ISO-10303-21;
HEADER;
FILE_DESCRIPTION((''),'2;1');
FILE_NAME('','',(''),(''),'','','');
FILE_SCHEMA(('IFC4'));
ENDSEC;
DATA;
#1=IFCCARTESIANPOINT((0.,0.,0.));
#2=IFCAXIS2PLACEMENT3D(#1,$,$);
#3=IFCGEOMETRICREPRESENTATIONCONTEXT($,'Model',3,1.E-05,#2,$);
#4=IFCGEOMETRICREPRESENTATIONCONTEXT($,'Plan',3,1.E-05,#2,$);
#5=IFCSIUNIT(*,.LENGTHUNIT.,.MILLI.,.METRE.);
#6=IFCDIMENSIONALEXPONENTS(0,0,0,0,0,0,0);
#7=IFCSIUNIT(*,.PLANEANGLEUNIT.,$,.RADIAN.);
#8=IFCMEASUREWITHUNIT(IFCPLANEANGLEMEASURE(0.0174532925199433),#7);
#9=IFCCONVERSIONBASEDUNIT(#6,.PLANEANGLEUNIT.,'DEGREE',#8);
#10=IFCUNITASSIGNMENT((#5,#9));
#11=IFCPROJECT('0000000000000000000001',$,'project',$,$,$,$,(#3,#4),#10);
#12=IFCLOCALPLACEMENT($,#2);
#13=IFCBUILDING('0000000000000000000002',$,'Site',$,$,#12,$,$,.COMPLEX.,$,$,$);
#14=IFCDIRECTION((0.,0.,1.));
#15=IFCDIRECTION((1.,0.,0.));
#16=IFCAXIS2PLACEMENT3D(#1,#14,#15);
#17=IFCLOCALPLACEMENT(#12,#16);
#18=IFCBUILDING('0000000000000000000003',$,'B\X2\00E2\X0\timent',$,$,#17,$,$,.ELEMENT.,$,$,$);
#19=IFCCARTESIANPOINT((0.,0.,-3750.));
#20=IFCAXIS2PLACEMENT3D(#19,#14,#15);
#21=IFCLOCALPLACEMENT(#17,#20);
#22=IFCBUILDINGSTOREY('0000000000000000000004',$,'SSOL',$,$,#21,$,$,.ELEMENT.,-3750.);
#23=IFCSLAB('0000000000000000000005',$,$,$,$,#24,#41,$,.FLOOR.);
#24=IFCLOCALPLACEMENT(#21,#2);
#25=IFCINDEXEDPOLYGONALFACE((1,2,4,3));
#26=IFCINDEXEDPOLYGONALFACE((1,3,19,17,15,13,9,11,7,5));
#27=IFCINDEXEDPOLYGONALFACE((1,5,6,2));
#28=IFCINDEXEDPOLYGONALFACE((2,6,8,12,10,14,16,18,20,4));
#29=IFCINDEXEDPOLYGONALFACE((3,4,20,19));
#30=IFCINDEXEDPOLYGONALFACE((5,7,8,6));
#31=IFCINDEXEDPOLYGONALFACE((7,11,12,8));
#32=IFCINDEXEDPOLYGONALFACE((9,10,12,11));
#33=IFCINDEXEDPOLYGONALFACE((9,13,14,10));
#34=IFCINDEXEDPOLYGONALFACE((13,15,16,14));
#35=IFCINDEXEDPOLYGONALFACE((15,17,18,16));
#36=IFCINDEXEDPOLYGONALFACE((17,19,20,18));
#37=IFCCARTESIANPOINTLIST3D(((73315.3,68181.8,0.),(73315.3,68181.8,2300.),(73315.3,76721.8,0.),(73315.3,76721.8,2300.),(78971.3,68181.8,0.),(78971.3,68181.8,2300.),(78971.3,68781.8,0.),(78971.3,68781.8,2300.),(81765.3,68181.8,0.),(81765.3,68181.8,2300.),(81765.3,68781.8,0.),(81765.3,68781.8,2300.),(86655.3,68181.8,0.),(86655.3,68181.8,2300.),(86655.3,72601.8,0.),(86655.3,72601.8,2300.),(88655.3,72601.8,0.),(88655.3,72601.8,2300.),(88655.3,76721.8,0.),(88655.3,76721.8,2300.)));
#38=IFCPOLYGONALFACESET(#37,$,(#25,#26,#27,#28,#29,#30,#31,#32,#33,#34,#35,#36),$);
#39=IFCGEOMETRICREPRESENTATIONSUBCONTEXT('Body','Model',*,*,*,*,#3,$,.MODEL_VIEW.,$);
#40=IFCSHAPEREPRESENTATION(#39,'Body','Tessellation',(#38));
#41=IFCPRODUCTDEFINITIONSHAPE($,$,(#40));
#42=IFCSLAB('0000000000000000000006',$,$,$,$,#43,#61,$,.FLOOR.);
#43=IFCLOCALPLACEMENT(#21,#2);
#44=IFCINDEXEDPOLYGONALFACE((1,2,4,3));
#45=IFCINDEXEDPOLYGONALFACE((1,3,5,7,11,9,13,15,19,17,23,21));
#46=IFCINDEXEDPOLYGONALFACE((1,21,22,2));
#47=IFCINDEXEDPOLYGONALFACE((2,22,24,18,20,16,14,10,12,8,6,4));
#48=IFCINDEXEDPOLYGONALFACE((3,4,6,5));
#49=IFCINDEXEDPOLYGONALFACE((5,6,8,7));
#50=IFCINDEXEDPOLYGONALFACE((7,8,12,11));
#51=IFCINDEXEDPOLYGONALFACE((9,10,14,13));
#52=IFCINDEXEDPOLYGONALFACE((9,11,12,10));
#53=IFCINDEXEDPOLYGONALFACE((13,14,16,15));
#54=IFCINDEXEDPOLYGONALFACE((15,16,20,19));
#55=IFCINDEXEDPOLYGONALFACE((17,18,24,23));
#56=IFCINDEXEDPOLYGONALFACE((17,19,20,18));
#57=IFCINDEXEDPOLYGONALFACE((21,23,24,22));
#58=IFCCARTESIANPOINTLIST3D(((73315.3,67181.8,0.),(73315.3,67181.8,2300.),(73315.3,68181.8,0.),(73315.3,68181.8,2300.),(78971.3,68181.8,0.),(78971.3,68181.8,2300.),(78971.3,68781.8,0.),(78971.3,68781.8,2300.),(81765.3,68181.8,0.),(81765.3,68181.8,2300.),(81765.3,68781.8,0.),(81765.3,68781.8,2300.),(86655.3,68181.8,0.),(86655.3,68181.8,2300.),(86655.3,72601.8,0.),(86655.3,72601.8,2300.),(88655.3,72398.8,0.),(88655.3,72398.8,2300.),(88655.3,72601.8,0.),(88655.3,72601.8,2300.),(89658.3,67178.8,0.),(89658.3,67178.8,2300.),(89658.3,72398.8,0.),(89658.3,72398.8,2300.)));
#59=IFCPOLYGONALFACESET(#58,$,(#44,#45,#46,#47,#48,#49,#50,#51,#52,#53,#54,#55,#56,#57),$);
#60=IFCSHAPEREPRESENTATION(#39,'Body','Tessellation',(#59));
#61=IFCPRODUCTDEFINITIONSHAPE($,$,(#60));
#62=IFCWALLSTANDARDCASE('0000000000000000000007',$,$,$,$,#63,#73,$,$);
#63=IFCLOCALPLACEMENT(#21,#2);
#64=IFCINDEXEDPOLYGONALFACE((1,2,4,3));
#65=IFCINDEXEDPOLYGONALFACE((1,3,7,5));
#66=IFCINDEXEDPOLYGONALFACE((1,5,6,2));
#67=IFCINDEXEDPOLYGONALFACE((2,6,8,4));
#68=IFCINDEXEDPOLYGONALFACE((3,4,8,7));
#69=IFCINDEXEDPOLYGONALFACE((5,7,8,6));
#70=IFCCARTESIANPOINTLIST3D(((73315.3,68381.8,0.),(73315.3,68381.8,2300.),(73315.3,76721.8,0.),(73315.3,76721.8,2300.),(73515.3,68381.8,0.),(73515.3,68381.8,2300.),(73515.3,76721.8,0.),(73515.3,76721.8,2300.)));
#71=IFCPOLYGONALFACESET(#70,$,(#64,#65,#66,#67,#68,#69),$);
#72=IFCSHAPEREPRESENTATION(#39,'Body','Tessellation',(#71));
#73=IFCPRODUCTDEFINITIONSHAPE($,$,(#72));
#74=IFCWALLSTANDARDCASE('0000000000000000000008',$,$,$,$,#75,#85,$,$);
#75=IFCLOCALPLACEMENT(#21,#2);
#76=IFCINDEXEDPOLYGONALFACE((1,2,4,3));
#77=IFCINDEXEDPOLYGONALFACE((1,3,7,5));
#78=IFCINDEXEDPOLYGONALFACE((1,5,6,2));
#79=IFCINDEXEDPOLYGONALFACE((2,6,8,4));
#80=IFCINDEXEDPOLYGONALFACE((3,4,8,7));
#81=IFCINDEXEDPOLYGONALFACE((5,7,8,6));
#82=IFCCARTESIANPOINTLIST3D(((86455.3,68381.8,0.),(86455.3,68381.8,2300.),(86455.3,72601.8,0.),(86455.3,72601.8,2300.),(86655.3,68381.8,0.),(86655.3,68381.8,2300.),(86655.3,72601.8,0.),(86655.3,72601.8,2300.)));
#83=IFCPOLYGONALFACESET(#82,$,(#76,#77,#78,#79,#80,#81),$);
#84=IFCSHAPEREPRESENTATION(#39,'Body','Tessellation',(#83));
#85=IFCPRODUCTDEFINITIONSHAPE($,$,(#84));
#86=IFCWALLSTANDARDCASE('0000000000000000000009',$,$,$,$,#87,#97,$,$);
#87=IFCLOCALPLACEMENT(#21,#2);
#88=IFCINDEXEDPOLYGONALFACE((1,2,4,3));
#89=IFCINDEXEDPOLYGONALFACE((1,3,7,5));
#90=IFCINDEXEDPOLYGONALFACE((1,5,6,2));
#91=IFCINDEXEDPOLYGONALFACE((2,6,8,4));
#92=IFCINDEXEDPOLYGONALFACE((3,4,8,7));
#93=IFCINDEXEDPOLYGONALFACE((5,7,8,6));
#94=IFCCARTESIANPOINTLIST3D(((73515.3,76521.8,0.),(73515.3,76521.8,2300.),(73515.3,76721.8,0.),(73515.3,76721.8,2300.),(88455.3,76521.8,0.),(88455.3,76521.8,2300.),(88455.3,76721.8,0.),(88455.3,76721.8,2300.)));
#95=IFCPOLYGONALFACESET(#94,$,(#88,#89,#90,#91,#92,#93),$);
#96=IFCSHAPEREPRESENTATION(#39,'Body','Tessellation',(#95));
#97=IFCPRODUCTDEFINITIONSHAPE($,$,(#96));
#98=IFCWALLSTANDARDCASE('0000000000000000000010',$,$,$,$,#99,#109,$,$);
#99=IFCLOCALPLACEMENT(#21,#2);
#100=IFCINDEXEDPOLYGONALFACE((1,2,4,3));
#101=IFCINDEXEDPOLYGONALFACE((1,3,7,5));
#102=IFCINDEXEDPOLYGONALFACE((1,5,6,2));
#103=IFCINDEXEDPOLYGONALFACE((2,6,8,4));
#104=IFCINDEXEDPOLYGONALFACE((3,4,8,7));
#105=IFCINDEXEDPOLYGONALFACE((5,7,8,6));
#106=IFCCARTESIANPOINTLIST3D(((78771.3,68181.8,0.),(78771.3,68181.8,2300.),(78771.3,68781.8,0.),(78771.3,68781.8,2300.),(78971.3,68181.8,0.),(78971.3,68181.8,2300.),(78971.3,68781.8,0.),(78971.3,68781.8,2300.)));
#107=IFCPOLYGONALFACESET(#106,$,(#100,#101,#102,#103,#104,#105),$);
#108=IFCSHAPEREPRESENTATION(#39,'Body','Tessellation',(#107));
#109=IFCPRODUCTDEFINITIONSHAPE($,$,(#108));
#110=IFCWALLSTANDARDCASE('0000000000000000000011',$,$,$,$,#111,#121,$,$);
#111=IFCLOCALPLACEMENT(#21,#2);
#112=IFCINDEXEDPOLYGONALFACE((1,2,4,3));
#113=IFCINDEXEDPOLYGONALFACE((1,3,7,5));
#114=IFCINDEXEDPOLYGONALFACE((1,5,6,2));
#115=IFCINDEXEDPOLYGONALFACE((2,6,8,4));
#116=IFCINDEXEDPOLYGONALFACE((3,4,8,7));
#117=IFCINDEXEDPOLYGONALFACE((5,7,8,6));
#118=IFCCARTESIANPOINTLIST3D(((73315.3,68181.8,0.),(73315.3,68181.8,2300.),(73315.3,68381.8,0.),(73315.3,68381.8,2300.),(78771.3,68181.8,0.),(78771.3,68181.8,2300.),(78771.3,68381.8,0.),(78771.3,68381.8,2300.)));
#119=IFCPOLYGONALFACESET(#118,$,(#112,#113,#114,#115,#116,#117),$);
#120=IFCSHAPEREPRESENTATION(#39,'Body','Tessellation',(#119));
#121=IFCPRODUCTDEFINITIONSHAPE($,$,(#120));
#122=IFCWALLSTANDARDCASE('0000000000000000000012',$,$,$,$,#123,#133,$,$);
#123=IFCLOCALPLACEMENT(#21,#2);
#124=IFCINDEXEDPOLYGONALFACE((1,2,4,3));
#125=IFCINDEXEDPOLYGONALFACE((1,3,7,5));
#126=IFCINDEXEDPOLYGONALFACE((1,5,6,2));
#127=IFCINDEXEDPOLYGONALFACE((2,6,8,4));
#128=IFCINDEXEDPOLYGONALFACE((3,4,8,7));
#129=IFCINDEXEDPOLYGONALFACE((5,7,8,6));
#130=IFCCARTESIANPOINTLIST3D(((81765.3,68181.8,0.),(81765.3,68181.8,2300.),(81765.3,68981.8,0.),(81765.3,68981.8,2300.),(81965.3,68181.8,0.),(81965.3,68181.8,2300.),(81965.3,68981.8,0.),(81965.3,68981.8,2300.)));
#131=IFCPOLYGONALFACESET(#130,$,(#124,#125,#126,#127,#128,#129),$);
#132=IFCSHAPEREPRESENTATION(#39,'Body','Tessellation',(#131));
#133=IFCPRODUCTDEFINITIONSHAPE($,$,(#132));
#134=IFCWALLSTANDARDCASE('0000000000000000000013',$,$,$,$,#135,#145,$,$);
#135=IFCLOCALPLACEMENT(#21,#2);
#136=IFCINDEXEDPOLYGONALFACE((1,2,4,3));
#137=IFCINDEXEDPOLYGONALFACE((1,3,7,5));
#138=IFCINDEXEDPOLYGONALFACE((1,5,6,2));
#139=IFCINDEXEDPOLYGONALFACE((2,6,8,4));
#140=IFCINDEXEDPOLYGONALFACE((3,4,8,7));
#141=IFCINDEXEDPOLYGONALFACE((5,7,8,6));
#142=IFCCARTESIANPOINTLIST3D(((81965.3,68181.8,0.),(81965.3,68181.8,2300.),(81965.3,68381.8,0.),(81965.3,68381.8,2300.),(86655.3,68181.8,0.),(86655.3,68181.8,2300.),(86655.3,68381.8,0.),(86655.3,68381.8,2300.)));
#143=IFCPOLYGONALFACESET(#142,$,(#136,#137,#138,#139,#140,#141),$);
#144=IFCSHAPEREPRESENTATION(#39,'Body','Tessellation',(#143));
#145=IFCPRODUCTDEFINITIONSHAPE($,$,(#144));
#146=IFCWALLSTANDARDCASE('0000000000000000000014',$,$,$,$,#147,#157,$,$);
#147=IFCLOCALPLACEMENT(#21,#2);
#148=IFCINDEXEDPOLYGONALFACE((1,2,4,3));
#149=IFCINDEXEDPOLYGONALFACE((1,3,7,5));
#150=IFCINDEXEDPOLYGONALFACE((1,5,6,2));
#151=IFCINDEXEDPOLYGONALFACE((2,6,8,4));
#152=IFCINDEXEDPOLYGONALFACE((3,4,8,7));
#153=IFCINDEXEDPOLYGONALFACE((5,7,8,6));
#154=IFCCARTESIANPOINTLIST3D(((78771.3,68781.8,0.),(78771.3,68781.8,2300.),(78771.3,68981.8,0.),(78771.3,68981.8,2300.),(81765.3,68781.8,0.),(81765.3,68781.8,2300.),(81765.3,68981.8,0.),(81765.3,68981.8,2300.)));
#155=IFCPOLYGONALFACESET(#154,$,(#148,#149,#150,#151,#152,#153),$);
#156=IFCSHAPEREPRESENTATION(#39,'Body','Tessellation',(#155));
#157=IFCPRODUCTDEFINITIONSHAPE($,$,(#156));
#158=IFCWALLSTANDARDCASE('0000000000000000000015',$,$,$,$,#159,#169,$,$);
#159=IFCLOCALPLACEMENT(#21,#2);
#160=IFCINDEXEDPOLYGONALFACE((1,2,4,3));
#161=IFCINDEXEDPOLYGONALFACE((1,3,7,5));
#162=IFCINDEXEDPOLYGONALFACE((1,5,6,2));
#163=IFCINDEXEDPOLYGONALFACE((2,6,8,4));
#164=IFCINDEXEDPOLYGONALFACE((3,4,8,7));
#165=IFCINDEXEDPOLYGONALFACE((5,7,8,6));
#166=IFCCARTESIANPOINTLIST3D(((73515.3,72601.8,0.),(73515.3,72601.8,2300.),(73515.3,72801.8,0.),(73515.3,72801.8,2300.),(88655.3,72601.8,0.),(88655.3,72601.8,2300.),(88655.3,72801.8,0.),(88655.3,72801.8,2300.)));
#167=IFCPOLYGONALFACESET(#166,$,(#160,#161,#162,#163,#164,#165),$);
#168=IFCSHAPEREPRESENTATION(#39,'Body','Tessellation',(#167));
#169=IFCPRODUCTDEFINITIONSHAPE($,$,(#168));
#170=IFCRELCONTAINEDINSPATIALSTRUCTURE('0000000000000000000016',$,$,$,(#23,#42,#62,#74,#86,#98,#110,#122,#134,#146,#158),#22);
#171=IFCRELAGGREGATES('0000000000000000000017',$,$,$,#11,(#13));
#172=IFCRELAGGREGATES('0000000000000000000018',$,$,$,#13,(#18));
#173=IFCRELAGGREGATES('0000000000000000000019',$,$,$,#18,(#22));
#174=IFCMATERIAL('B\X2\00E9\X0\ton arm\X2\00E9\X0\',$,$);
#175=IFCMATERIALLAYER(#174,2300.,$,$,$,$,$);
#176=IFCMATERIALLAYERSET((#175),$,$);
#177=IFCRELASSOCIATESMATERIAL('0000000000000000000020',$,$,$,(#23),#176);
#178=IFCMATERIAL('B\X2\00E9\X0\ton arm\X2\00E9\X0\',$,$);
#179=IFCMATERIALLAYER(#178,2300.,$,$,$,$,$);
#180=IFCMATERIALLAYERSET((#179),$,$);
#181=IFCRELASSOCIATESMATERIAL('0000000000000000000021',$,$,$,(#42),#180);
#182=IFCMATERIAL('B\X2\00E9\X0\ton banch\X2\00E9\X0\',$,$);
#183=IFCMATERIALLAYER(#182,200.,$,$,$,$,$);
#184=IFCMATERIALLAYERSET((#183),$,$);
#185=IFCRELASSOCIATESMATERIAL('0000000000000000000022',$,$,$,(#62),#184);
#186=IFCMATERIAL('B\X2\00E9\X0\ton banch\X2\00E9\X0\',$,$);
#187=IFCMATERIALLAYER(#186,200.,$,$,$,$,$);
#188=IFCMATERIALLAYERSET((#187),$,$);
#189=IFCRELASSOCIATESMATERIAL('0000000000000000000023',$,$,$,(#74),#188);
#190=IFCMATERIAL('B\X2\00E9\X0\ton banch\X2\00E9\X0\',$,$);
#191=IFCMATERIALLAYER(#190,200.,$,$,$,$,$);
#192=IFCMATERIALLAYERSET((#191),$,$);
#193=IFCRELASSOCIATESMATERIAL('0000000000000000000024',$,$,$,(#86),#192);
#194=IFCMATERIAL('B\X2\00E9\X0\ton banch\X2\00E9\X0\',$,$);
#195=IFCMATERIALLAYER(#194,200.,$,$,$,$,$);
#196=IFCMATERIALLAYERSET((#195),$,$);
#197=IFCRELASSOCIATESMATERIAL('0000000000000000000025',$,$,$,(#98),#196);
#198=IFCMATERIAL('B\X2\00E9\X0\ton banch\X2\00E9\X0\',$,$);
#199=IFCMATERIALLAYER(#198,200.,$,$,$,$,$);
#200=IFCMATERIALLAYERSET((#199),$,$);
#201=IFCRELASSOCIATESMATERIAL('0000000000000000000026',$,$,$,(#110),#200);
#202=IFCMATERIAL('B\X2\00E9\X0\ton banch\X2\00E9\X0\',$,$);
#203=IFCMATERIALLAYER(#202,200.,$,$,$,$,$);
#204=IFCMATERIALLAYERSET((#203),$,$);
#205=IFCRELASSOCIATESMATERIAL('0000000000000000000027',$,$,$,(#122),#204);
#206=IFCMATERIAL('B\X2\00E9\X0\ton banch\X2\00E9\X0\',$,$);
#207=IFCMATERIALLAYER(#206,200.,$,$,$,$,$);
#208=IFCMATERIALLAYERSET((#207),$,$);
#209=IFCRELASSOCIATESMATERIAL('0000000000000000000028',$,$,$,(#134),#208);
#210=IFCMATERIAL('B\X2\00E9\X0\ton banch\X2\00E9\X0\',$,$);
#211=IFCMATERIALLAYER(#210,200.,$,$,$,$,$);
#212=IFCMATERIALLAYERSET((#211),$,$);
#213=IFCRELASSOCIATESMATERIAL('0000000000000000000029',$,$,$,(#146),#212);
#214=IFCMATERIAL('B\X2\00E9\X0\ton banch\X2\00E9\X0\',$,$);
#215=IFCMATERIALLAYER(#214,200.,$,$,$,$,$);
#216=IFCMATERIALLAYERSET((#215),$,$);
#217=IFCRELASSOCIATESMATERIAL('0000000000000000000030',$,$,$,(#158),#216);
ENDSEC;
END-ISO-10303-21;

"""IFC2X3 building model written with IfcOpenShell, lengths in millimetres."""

from ifc_helpers import new_model, entity, si_unit, converted_unit, frame, frame_2d, origin, origin_with_axes, place, context, subcontext, project, spatial, polyline, rectangle, outline, extrude, material, layer, layer_set, layer_usage, element, save


model = new_model("IFC2X3")

# Units and contexts
model_context = context("Model", 3, precision=1e-05, world=origin())
plan_context = context("Plan", 3, precision=1e-05, world=origin())
body_context = subcontext(model_context, "Body", "Model", "MODEL_VIEW")
ifc_project = project(units=[si_unit("LENGTHUNIT", "METRE", prefix="MILLI"), converted_unit("PLANEANGLEUNIT", "DEGREE", entity("IfcPlaneAngleMeasure", 0.0174532925199433), si_unit("PLANEANGLEUNIT", "RADIAN"), dimensions=[0, 0, 0, 0, 0, 0, 0])], contexts=[model_context, plan_context])

# Buildings, storey
building_1_placement = place(None, origin())
building_1 = spatial("IfcBuilding", under=ifc_project, at=building_1_placement, Name="Site", CompositionType="COMPLEX")
building_2_placement = place(building_1_placement, origin_with_axes())
building_2 = spatial("IfcBuilding", under=building_1, at=building_2_placement, Name="Bâtiment", CompositionType="ELEMENT")
storey_placement = place(building_2_placement, frame((0.0, 0.0, -3750.0), z_axis=(0.0, 0.0, 1.0), x_axis=(1.0, 0.0, 0.0)))
storey = spatial("IfcBuildingStorey", under=building_2, at=storey_placement, Name="SSOL", CompositionType="ELEMENT", Elevation=-3750.0)

# Slabs
ifc_material_1 = material(Name="Béton armé")
ifc_layer_1 = layer(ifc_material_1, 2300.0)
ifc_layer_set_1 = layer_set([ifc_layer_1])
ifc_layer_usage_1 = layer_usage(ifc_layer_set_1, "AXIS3", "POSITIVE", 0.0)
slab_1_placement = place(storey_placement, frame((73315.3, 68181.8, 0.0), z_axis=(0.0, 0.0, 1.0), x_axis=(1.0, 0.0, 0.0)))
element("IfcSlab", 1, at=slab_1_placement, inside=storey, material=ifc_layer_usage_1, PredefinedType="FLOOR", context=body_context, shape_type="SweptSolid", body=[
    extrude(outline(polyline([(15340.0, 4420.0), (15340.0, 8540.0), (0.0, 8540.0), (0.0, 0.0), (5656.0, 0.0), (5656.0, 600.0), (8450.0, 600.0), (8450.0, 0.0), (13340.0, 0.0), (13340.0, 4420.0), (15340.0, 4420.0)])), origin_with_axes(), (0.0, 0.0, 1.0), 2300.0),
])
ifc_material_2 = material(Name="Béton armé")
ifc_layer_2 = layer(ifc_material_2, 2300.0)
ifc_layer_set_2 = layer_set([ifc_layer_2])
ifc_layer_usage_2 = layer_usage(ifc_layer_set_2, "AXIS3", "POSITIVE", 0.0)
slab_2_placement = place(storey_placement, frame((73315.3, 67178.8, 0.0), z_axis=(0.0, 0.0, 1.0), x_axis=(1.0, 0.0, 0.0)))
element("IfcSlab", 2, at=slab_2_placement, inside=storey, material=ifc_layer_usage_2, PredefinedType="FLOOR", context=body_context, shape_type="SweptSolid", body=[
    extrude(outline(polyline([(13340.0, 5423.0), (13340.0, 1003.0), (8450.0, 1003.0), (8450.0, 1603.0), (5656.0, 1603.0), (5656.0, 1003.0), (0.0, 1003.0), (0.0, 3.0), (16343.0, 0.0), (16343.0, 5220.0), (15340.0, 5220.0), (15340.0, 5423.0), (13340.0, 5423.0)])), origin_with_axes(), (0.0, 0.0, 1.0), 2300.0),
])

# Walls
ifc_material_3 = material(Name="Béton banché")
ifc_layer_3 = layer(ifc_material_3, 200.0)
ifc_layer_set_3 = layer_set([ifc_layer_3])
ifc_layer_usage_3 = layer_usage(ifc_layer_set_3, "AXIS2", "POSITIVE", 0.0)
wall_1_placement = place(storey_placement, frame((73315.3, 76721.8, 0.0), z_axis=(0.0, 0.0, 1.0), x_axis=(0.0, -1.0, 0.0)))
element("IfcWallStandardCase", 3, at=wall_1_placement, inside=storey, material=ifc_layer_usage_3, context=body_context, shape_type="SweptSolid", body=[
    extrude(rectangle(XDim=8340.0, YDim=200.0, at=frame_2d((4170.0, 100.0), x_axis=(1.0, 0.0))), origin_with_axes(), (0.0, 0.0, 1.0), 2300.0),
])
ifc_material_4 = material(Name="Béton banché")
ifc_layer_4 = layer(ifc_material_4, 200.0)
ifc_layer_set_4 = layer_set([ifc_layer_4])
ifc_layer_usage_4 = layer_usage(ifc_layer_set_4, "AXIS2", "POSITIVE", 0.0)
wall_2_placement = place(storey_placement, frame((86655.3, 68381.8, 0.0), z_axis=(0.0, 0.0, 1.0), x_axis=(0.0, 1.0, 0.0)))
element("IfcWallStandardCase", 4, at=wall_2_placement, inside=storey, material=ifc_layer_usage_4, context=body_context, shape_type="SweptSolid", body=[
    extrude(rectangle(XDim=4220.0, YDim=200.0, at=frame_2d((2110.0, 100.0), x_axis=(1.0, 0.0))), origin_with_axes(), (0.0, 0.0, 1.0), 2300.0),
])
ifc_material_5 = material(Name="Béton banché")
ifc_layer_5 = layer(ifc_material_5, 200.0)
ifc_layer_set_5 = layer_set([ifc_layer_5])
ifc_layer_usage_5 = layer_usage(ifc_layer_set_5, "AXIS2", "POSITIVE", 0.0)
wall_3_placement = place(storey_placement, frame((88455.3, 76721.8, 0.0), z_axis=(0.0, 0.0, 1.0), x_axis=(-1.0, 0.0, 0.0)))
element("IfcWallStandardCase", 5, at=wall_3_placement, inside=storey, material=ifc_layer_usage_5, context=body_context, shape_type="SweptSolid", body=[
    extrude(rectangle(XDim=14940.0, YDim=200.0, at=frame_2d((7470.0, 100.0), x_axis=(1.0, 0.0))), origin_with_axes(), (0.0, 0.0, 1.0), 2300.0),
])
ifc_material_6 = material(Name="Béton banché")
ifc_layer_6 = layer(ifc_material_6, 200.0)
ifc_layer_set_6 = layer_set([ifc_layer_6])
ifc_layer_usage_6 = layer_usage(ifc_layer_set_6, "AXIS2", "POSITIVE", 0.0)
wall_4_placement = place(storey_placement, frame((78971.3, 68181.8, 0.0), z_axis=(0.0, 0.0, 1.0), x_axis=(0.0, 1.0, 0.0)))
element("IfcWallStandardCase", 6, at=wall_4_placement, inside=storey, material=ifc_layer_usage_6, context=body_context, shape_type="SweptSolid", body=[
    extrude(rectangle(XDim=600.0, YDim=200.0, at=frame_2d((300.0, 100.0), x_axis=(1.0, 0.0))), origin_with_axes(), (0.0, 0.0, 1.0), 2300.0),
])
ifc_material_7 = material(Name="Béton banché")
ifc_layer_7 = layer(ifc_material_7, 200.0)
ifc_layer_set_7 = layer_set([ifc_layer_7])
ifc_layer_usage_7 = layer_usage(ifc_layer_set_7, "AXIS2", "POSITIVE", 0.0)
wall_5_placement = place(storey_placement, frame((73315.3, 68181.8, 0.0), z_axis=(0.0, 0.0, 1.0), x_axis=(1.0, 0.0, 0.0)))
element("IfcWallStandardCase", 7, at=wall_5_placement, inside=storey, material=ifc_layer_usage_7, context=body_context, shape_type="SweptSolid", body=[
    extrude(rectangle(XDim=5456.0, YDim=200.0, at=frame_2d((2728.0, 100.0), x_axis=(1.0, 0.0))), origin_with_axes(), (0.0, 0.0, 1.0), 2300.0),
])
ifc_material_8 = material(Name="Béton banché")
ifc_layer_8 = layer(ifc_material_8, 200.0)
ifc_layer_set_8 = layer_set([ifc_layer_8])
ifc_layer_usage_8 = layer_usage(ifc_layer_set_8, "AXIS2", "POSITIVE", 0.0)
wall_6_placement = place(storey_placement, frame((81765.3, 68981.8, 0.0), z_axis=(0.0, 0.0, 1.0), x_axis=(0.0, -1.0, 0.0)))
element("IfcWallStandardCase", 8, at=wall_6_placement, inside=storey, material=ifc_layer_usage_8, context=body_context, shape_type="SweptSolid", body=[
    extrude(rectangle(XDim=800.0, YDim=200.0, at=frame_2d((400.0, 100.0), x_axis=(1.0, 0.0))), origin_with_axes(), (0.0, 0.0, 1.0), 2300.0),
])
ifc_material_9 = material(Name="Béton banché")
ifc_layer_9 = layer(ifc_material_9, 200.0)
ifc_layer_set_9 = layer_set([ifc_layer_9])
ifc_layer_usage_9 = layer_usage(ifc_layer_set_9, "AXIS2", "POSITIVE", 0.0)
wall_7_placement = place(storey_placement, frame((81965.3, 68181.8, 0.0), z_axis=(0.0, 0.0, 1.0), x_axis=(1.0, 0.0, 0.0)))
element("IfcWallStandardCase", 9, at=wall_7_placement, inside=storey, material=ifc_layer_usage_9, context=body_context, shape_type="SweptSolid", body=[
    extrude(rectangle(XDim=4690.0, YDim=200.0, at=frame_2d((2345.0, 100.0), x_axis=(1.0, 0.0))), origin_with_axes(), (0.0, 0.0, 1.0), 2300.0),
])
ifc_material_10 = material(Name="Béton banché")
ifc_layer_10 = layer(ifc_material_10, 200.0)
ifc_layer_set_10 = layer_set([ifc_layer_10])
ifc_layer_usage_10 = layer_usage(ifc_layer_set_10, "AXIS2", "POSITIVE", 0.0)
wall_8_placement = place(storey_placement, frame((81765.3, 68981.8, 0.0), z_axis=(0.0, 0.0, 1.0), x_axis=(-1.0, 0.0, 0.0)))
element("IfcWallStandardCase", 10, at=wall_8_placement, inside=storey, material=ifc_layer_usage_10, context=body_context, shape_type="SweptSolid", body=[
    extrude(rectangle(XDim=2994.0, YDim=200.0, at=frame_2d((1497.0, 100.0), x_axis=(1.0, 0.0))), origin_with_axes(), (0.0, 0.0, 1.0), 2300.0),
])
ifc_material_11 = material(Name="Béton banché")
ifc_layer_11 = layer(ifc_material_11, 200.0)
ifc_layer_set_11 = layer_set([ifc_layer_11])
ifc_layer_usage_11 = layer_usage(ifc_layer_set_11, "AXIS2", "POSITIVE", 0.0)
wall_9_placement = place(storey_placement, frame((73515.3, 72601.8, 0.0), z_axis=(0.0, 0.0, 1.0), x_axis=(1.0, 0.0, 0.0)))
element("IfcWallStandardCase", 11, at=wall_9_placement, inside=storey, material=ifc_layer_usage_11, context=body_context, shape_type="SweptSolid", body=[
    extrude(rectangle(XDim=15140.0, YDim=200.0, at=frame_2d((7570.0, 100.0), x_axis=(1.0, 0.0))), origin_with_axes(), (0.0, 0.0, 1.0), 2300.0),
])

save(model, "model.ifc")
